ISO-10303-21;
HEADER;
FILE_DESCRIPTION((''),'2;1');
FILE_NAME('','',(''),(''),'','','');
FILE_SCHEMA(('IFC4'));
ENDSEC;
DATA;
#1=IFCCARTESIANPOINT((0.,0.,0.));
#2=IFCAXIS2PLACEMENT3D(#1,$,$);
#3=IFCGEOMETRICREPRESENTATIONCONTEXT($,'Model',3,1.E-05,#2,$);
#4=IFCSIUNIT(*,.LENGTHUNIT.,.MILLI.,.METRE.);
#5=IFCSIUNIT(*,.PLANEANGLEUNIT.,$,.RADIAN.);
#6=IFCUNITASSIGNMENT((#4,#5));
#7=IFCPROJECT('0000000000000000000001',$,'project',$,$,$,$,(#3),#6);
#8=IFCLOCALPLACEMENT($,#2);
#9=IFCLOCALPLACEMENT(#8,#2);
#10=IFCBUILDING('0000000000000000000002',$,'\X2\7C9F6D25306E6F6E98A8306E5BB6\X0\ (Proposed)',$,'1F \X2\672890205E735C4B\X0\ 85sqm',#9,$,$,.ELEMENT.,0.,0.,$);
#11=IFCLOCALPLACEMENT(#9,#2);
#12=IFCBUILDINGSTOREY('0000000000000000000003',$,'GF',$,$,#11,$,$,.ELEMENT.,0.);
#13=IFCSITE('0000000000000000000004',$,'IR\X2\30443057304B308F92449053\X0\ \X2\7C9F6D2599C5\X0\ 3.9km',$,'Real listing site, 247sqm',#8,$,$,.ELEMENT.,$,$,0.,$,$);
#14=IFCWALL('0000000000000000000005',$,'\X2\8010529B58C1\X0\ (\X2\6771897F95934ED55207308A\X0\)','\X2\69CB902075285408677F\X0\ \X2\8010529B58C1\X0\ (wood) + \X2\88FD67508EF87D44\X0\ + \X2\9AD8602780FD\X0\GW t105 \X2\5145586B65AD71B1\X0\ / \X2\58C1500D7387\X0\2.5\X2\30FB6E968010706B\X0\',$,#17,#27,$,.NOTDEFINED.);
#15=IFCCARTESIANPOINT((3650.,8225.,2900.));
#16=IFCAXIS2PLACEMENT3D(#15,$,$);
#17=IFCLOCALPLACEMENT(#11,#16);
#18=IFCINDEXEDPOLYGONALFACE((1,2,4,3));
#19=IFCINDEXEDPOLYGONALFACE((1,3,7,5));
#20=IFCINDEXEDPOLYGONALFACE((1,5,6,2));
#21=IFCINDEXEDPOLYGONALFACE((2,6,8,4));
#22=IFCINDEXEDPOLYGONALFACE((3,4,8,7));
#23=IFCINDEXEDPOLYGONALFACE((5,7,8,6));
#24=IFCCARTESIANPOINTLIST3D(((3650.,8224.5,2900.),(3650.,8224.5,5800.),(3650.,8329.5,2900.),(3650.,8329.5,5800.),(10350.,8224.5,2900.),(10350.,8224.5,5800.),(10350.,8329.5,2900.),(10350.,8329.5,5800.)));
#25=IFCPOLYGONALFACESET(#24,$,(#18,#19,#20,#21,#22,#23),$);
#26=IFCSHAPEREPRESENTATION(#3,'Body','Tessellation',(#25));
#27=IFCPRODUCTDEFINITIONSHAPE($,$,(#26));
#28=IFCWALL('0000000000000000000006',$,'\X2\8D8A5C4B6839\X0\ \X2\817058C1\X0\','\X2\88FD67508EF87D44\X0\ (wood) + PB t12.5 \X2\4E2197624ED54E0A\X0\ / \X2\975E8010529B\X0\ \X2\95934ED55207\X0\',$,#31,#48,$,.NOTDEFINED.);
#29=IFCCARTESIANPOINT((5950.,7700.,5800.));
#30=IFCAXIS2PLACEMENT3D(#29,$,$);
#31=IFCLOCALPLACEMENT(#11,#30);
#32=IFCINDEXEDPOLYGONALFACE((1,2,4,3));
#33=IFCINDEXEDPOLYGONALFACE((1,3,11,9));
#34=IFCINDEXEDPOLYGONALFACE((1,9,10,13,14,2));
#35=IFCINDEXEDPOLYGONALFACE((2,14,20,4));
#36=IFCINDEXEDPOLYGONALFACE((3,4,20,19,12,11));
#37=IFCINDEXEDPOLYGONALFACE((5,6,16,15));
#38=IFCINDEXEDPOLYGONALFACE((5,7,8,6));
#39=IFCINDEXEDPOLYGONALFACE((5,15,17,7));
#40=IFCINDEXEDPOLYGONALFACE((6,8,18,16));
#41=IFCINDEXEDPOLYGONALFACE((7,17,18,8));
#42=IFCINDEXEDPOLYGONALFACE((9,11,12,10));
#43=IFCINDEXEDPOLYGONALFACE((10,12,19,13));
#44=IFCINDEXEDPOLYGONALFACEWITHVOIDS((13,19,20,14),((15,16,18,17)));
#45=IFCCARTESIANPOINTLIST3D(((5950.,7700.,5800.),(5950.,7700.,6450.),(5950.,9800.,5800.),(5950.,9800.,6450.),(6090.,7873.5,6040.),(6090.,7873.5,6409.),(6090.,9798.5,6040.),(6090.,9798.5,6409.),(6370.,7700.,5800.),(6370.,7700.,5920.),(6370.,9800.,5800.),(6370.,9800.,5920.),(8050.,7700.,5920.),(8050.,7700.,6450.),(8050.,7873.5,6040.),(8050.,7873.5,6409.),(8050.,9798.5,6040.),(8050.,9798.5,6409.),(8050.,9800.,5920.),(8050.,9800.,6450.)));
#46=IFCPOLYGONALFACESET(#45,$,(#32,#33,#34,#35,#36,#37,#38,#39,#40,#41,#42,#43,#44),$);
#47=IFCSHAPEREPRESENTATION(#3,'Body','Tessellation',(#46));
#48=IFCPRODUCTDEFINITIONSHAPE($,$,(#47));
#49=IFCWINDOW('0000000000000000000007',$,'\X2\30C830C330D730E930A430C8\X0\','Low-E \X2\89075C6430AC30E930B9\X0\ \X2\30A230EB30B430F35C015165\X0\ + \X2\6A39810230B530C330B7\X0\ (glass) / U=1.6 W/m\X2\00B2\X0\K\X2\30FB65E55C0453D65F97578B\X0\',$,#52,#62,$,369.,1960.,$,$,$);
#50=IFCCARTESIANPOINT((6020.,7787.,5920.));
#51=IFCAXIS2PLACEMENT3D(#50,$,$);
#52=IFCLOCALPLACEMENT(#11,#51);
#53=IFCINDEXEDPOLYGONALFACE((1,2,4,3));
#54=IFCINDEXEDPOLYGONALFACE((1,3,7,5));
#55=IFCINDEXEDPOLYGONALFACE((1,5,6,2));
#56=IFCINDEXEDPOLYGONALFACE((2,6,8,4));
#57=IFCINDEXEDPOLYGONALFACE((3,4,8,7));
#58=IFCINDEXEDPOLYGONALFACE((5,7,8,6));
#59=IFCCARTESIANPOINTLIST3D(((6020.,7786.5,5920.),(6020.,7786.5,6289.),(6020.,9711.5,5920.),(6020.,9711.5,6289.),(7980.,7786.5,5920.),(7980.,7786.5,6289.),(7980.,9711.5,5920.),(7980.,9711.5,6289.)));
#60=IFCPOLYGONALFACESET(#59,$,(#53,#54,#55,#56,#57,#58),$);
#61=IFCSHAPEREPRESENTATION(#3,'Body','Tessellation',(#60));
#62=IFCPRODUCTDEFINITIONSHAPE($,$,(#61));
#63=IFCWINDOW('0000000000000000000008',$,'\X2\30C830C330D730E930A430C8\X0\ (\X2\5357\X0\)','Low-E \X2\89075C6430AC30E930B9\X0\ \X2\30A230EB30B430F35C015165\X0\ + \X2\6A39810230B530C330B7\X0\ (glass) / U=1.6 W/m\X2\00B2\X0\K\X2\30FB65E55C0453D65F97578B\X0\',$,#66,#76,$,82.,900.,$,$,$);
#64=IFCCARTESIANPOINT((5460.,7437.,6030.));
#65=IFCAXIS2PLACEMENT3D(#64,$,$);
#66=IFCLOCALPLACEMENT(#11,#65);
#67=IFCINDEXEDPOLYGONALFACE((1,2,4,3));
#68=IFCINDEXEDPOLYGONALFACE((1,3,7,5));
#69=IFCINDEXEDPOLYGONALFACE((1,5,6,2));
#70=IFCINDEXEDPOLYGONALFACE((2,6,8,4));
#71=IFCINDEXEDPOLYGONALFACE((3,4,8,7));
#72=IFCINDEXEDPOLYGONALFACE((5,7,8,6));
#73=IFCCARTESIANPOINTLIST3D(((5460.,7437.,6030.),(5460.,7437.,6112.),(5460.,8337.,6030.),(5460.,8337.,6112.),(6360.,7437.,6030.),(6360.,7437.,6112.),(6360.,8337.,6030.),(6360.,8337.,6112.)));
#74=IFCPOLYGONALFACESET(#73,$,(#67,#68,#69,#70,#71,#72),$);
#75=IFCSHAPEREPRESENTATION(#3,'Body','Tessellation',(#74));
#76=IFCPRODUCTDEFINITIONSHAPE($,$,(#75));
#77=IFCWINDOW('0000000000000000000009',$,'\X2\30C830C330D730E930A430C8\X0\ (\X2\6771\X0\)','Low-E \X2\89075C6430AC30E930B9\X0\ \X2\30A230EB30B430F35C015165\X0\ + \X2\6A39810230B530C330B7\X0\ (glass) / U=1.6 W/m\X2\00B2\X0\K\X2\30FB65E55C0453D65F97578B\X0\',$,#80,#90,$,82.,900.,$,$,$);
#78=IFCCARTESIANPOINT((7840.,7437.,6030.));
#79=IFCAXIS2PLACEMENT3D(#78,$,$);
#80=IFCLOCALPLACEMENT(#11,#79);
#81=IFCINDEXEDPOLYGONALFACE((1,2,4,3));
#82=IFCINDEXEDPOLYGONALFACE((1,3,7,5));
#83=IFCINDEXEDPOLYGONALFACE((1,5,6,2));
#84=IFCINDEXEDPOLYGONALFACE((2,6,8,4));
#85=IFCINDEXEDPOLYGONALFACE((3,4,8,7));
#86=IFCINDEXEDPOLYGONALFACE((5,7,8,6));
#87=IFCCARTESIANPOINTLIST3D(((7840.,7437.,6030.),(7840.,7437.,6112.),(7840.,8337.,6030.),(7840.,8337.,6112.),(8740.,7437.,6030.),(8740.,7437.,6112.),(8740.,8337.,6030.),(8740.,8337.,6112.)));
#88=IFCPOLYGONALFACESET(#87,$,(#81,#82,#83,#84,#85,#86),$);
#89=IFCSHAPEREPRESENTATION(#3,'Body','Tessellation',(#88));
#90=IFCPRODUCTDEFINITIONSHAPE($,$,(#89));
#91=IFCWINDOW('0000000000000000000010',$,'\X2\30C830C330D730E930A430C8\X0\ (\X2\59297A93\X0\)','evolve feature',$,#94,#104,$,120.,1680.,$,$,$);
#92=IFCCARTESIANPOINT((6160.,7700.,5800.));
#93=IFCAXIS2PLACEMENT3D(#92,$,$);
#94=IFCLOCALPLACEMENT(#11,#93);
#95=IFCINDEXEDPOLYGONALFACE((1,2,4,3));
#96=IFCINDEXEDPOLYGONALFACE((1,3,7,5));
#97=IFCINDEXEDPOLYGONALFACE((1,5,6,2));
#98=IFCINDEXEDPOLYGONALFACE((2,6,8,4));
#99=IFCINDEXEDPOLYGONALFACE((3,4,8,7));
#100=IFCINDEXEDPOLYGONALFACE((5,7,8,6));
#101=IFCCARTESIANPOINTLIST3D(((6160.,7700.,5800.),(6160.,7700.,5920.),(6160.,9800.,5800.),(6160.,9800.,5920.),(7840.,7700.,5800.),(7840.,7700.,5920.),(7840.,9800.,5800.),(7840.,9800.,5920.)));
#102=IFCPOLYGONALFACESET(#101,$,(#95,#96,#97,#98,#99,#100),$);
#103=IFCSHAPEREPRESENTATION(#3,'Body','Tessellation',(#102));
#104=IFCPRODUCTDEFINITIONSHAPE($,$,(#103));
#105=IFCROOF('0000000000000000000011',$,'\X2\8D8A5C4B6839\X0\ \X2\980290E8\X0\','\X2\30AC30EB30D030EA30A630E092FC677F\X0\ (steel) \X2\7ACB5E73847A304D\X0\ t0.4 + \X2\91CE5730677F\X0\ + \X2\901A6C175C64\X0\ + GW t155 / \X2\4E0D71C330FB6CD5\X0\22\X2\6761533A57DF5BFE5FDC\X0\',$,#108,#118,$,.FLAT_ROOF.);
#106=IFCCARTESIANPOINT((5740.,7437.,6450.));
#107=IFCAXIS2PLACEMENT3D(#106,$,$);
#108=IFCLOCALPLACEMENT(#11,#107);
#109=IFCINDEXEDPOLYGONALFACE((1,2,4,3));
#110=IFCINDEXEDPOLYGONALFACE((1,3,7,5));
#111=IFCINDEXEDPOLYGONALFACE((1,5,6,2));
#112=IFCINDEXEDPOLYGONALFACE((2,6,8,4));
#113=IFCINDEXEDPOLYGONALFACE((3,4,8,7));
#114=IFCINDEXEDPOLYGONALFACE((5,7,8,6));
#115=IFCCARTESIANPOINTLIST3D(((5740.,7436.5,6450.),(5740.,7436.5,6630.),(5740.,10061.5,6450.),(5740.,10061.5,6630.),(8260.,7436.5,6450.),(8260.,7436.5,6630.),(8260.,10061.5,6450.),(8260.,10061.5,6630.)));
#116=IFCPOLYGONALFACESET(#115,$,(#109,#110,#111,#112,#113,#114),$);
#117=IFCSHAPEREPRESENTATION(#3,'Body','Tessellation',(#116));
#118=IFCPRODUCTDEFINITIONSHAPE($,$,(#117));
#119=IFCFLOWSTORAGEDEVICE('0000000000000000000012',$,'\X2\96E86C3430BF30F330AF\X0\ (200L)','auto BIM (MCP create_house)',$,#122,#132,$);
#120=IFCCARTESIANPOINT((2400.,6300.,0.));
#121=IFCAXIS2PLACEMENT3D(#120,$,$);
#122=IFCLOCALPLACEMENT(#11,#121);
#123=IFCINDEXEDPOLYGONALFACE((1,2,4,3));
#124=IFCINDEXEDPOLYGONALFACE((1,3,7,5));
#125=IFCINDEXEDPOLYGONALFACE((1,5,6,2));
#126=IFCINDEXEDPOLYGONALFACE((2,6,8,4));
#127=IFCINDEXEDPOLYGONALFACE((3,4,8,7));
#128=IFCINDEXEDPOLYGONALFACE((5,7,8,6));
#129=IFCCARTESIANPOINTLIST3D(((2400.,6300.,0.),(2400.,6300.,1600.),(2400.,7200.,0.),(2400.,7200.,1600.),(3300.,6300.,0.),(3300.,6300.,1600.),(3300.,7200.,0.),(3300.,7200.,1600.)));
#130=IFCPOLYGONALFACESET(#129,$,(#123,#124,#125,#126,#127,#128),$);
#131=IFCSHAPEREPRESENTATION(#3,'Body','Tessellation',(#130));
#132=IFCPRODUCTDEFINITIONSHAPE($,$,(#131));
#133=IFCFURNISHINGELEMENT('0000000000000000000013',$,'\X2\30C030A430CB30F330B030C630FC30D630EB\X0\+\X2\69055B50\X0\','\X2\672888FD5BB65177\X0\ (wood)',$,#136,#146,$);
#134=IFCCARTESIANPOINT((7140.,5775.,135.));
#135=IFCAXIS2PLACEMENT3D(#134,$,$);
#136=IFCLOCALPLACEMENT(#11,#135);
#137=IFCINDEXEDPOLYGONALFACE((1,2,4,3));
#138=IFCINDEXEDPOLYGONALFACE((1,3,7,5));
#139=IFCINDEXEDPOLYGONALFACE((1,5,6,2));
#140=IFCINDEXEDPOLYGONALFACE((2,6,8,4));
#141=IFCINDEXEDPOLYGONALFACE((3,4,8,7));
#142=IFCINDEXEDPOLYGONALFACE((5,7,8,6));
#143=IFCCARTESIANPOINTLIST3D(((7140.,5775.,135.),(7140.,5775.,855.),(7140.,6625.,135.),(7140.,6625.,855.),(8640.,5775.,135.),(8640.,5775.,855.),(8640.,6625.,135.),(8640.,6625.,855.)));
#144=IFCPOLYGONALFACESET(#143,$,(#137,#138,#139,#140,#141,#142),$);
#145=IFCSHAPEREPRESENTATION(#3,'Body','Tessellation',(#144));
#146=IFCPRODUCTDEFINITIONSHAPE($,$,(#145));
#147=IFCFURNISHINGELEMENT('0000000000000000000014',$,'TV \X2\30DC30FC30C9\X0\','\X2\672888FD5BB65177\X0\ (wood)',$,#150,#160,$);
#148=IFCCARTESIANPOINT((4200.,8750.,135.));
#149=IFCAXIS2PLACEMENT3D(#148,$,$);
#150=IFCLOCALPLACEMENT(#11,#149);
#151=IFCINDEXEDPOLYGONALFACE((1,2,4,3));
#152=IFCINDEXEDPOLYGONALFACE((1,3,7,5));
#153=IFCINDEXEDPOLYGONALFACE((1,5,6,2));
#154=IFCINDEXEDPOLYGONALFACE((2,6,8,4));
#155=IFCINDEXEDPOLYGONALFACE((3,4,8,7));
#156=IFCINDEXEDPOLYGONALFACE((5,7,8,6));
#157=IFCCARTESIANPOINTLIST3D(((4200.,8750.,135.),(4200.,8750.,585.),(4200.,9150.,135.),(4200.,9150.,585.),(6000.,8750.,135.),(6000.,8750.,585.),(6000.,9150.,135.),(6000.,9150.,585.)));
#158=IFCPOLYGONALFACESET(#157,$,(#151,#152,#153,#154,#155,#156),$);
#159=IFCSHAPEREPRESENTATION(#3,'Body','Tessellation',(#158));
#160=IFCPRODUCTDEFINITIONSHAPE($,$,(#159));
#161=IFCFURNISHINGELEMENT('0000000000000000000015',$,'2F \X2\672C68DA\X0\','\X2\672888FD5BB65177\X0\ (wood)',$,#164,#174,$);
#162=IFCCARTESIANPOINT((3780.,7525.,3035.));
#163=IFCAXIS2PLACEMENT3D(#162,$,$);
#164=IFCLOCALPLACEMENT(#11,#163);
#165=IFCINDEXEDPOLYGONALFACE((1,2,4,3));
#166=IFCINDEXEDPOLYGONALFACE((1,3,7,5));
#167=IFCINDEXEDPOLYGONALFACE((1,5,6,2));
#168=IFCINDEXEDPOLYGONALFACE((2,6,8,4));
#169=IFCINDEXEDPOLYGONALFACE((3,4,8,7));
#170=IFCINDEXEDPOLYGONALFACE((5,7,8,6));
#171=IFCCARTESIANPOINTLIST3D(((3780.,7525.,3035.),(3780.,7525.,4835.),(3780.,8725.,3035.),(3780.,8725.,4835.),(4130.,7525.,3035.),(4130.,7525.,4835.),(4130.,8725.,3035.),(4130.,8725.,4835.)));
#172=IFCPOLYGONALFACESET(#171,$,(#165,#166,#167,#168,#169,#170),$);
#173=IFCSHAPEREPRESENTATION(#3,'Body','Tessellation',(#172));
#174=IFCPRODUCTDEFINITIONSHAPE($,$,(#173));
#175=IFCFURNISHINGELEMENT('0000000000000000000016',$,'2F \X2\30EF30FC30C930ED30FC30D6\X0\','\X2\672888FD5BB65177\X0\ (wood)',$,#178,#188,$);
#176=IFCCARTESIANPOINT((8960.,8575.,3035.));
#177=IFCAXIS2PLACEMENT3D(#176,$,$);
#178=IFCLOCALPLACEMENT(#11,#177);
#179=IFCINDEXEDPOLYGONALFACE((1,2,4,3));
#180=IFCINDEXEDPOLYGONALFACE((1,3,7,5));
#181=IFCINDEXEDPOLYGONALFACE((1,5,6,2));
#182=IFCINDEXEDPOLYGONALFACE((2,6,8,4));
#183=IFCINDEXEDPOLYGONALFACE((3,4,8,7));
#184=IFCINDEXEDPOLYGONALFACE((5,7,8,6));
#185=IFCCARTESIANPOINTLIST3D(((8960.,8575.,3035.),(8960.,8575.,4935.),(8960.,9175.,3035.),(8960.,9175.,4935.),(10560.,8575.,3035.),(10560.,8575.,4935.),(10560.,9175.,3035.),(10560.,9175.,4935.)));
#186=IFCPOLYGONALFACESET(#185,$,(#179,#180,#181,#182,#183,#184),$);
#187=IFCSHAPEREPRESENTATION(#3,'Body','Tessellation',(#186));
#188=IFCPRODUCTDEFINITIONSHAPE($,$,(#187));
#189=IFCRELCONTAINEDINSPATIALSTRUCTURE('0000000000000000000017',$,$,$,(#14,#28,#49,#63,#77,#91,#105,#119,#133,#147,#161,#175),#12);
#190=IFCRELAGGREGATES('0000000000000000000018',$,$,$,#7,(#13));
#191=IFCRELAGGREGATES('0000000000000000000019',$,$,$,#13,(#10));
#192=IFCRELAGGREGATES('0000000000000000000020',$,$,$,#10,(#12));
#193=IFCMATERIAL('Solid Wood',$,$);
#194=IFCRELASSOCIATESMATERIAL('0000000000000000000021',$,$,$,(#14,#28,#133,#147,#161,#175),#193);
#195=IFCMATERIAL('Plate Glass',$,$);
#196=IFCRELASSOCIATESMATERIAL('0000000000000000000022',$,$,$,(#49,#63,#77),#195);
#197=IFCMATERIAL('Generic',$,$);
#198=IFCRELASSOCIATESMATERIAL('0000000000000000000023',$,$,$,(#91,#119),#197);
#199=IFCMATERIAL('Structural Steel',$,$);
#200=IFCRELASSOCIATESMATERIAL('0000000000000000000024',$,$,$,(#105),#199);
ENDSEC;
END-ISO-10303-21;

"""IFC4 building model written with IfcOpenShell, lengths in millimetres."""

from ifc_helpers import new_model, si_unit, frame, frame_2d, origin, place, context, project, spatial, rectangle, extrude, material, element, fill, save


model = new_model("IFC4")

# Units and contexts
model_context = context("Model", 3, precision=1e-05, world=origin())
ifc_project = project(units=[si_unit("LENGTHUNIT", "METRE", prefix="MILLI"), si_unit("PLANEANGLEUNIT", "RADIAN")], contexts=[model_context])

# Site, building, storey
site_placement = place(None, origin())
site = spatial("IfcSite", under=ifc_project, at=site_placement, Name="IRいしかわ鉄道 粟津駅 3.9km", ObjectType="Real listing site, 247sqm", CompositionType="ELEMENT", RefElevation=0.0)
building_placement = place(site_placement, origin())
building = spatial("IfcBuilding", under=site, at=building_placement, Name="粟津の潮風の家 (Proposed)", ObjectType="1F 木造平屋 85sqm", CompositionType="ELEMENT", ElevationOfRefHeight=0.0, ElevationOfTerrain=0.0)
storey_placement = place(building_placement, origin())
storey = spatial("IfcBuildingStorey", under=building, at=storey_placement, Name="GF", CompositionType="ELEMENT", Elevation=0.0)

# Wall
ifc_material_1 = material(Name="Solid Wood")
wall_1_placement = place(storey_placement, frame((3650.0, 8225.0, 2900.0)))
element("IfcWall", 1, at=wall_1_placement, inside=storey, material=ifc_material_1, Name="耐力壁 (東西間仕切り)", Description="構造用合板 耐力壁 (wood) + 製材軸組 + 高性能GW t105 充填断熱 / 壁倍率2.5・準耐火", PredefinedType="NOTDEFINED", context=model_context, shape_type="SweptSolid", body=[
    extrude(rectangle(XDim=6700.0, YDim=105.0, at=frame_2d((3350.0, 52.0))), frame((3650.0, 8225.0, 2900.0)), (0.0, 0.0, 1.0), 2900.0),
])

# Wall, openings, windows
wall_2_placement = place(storey_placement, frame((5950.0, 7700.0, 5800.0)))
wall_2 = element("IfcWall", 2, at=wall_2_placement, inside=storey, material=ifc_material_1, Name="越屋根 腰壁", Description="製材軸組 (wood) + PB t12.5 両面仕上 / 非耐力 間仕切", PredefinedType="NOTDEFINED", context=model_context, shape_type="SweptSolid", body=[
    extrude(rectangle(XDim=2100.0, YDim=2100.0, at=frame_2d((1050.0, 1050.0))), frame((5950.0, 7700.0, 5800.0)), (0.0, 0.0, 1.0), 650.0),
])
opening_1_placement = place(storey_placement, frame((6020.0, 7787.0, 5920.0)))
opening_1 = element("IfcOpeningElement", 3, at=opening_1_placement, cuts=wall_2, PredefinedType="NOTDEFINED", context=model_context, shape_type="SweptSolid", body=[
    extrude(rectangle(XDim=1960.0, YDim=1925.0, at=frame_2d((980.0, 962.0))), frame((6020.0, 7787.0, 5920.0)), (0.0, 0.0, 1.0), 369.0),
])
opening_2_placement = place(storey_placement, frame((5460.0, 7437.0, 6030.0)))
opening_2 = element("IfcOpeningElement", 4, at=opening_2_placement, cuts=wall_2, PredefinedType="NOTDEFINED", context=model_context, shape_type="SweptSolid", body=[
    extrude(rectangle(XDim=900.0, YDim=900.0, at=frame_2d((450.0, 450.0))), frame((5460.0, 7437.0, 6030.0)), (0.0, 0.0, 1.0), 82.0),
])
opening_3_placement = place(storey_placement, frame((7840.0, 7437.0, 6030.0)))
opening_3 = element("IfcOpeningElement", 5, at=opening_3_placement, cuts=wall_2, PredefinedType="NOTDEFINED", context=model_context, shape_type="SweptSolid", body=[
    extrude(rectangle(XDim=900.0, YDim=900.0, at=frame_2d((450.0, 450.0))), frame((7840.0, 7437.0, 6030.0)), (0.0, 0.0, 1.0), 82.0),
])
opening_4_placement = place(storey_placement, frame((6160.0, 7700.0, 5800.0)))
opening_4 = element("IfcOpeningElement", 6, at=opening_4_placement, cuts=wall_2, PredefinedType="NOTDEFINED", context=model_context, shape_type="SweptSolid", body=[
    extrude(rectangle(XDim=1680.0, YDim=2100.0, at=frame_2d((840.0, 1050.0))), frame((6160.0, 7700.0, 5800.0)), (0.0, 0.0, 1.0), 120.0),
])
ifc_material_2 = material(Name="Plate Glass")
window_1_placement = place(storey_placement, frame((6020.0, 7787.0, 5920.0)))
window_1 = element("IfcWindow", 7, at=window_1_placement, inside=storey, material=ifc_material_2, Name="トップライト", Description="Low-E 複層ガラス アルゴン封入 + 樹脂サッシ (glass) / U=1.6 W/m²K・日射取得型", OverallHeight=369.0, OverallWidth=1960.0, context=model_context, shape_type="SweptSolid", body=[
    extrude(rectangle(XDim=1960.0, YDim=1925.0, at=frame_2d((980.0, 962.0))), frame((6020.0, 7787.0, 5920.0)), (0.0, 0.0, 1.0), 369.0),
])
fill(opening_1, window_1)
window_2_placement = place(storey_placement, frame((5460.0, 7437.0, 6030.0)))
window_2 = element("IfcWindow", 8, at=window_2_placement, inside=storey, material=ifc_material_2, Name="トップライト (南)", Description="Low-E 複層ガラス アルゴン封入 + 樹脂サッシ (glass) / U=1.6 W/m²K・日射取得型", OverallHeight=82.0, OverallWidth=900.0, context=model_context, shape_type="SweptSolid", body=[
    extrude(rectangle(XDim=900.0, YDim=900.0, at=frame_2d((450.0, 450.0))), frame((5460.0, 7437.0, 6030.0)), (0.0, 0.0, 1.0), 82.0),
])
fill(opening_2, window_2)
window_3_placement = place(storey_placement, frame((7840.0, 7437.0, 6030.0)))
window_3 = element("IfcWindow", 9, at=window_3_placement, inside=storey, material=ifc_material_2, Name="トップライト (東)", Description="Low-E 複層ガラス アルゴン封入 + 樹脂サッシ (glass) / U=1.6 W/m²K・日射取得型", OverallHeight=82.0, OverallWidth=900.0, context=model_context, shape_type="SweptSolid", body=[
    extrude(rectangle(XDim=900.0, YDim=900.0, at=frame_2d((450.0, 450.0))), frame((7840.0, 7437.0, 6030.0)), (0.0, 0.0, 1.0), 82.0),
])
fill(opening_3, window_3)
ifc_material_3 = material(Name="Generic")
window_4_placement = place(storey_placement, frame((6160.0, 7700.0, 5800.0)))
window_4 = element("IfcWindow", 10, at=window_4_placement, inside=storey, material=ifc_material_3, Name="トップライト (天窓)", Description="evolve feature", OverallHeight=120.0, OverallWidth=1680.0, context=model_context, shape_type="SweptSolid", body=[
    extrude(rectangle(XDim=1680.0, YDim=2100.0, at=frame_2d((840.0, 1050.0))), frame((6160.0, 7700.0, 5800.0)), (0.0, 0.0, 1.0), 120.0),
])
fill(opening_4, window_4)

# Roof
ifc_material_4 = material(Name="Structural Steel")
roof_placement = place(storey_placement, frame((5740.0, 7437.0, 6450.0)))
element("IfcRoof", 11, at=roof_placement, inside=storey, material=ifc_material_4, Name="越屋根 頂部", Description="ガルバリウム鋼板 (steel) 立平葺き t0.4 + 野地板 + 通気層 + GW t155 / 不燃・法22条区域対応", PredefinedType="FLAT_ROOF", context=model_context, shape_type="SweptSolid", body=[
    extrude(rectangle(XDim=2520.0, YDim=2625.0, at=frame_2d((1260.0, 1312.0))), frame((5740.0, 7437.0, 6450.0)), (0.0, 0.0, 1.0), 180.0),
])

# Flow storage device
flow_storage_device_placement = place(storey_placement, frame((2400.0, 6300.0, 0.0)))
element("IfcFlowStorageDevice", 12, at=flow_storage_device_placement, inside=storey, material=ifc_material_3, Name="雨水タンク (200L)", Description="auto BIM (MCP create_house)", context=model_context, shape_type="SweptSolid", body=[
    extrude(rectangle(XDim=900.0, YDim=900.0, at=frame_2d((450.0, 450.0))), frame((2400.0, 6300.0, 0.0)), (0.0, 0.0, 1.0), 1600.0),
])

# Furnishing elements
furnishing_1_placement = place(storey_placement, frame((7140.0, 5775.0, 135.0)))
element("IfcFurnishingElement", 13, at=furnishing_1_placement, inside=storey, material=ifc_material_1, Name="ダイニングテーブル+椅子", Description="木製家具 (wood)", context=model_context, shape_type="SweptSolid", body=[
    extrude(rectangle(XDim=1500.0, YDim=850.0, at=frame_2d((750.0, 425.0))), frame((7140.0, 5775.0, 135.0)), (0.0, 0.0, 1.0), 720.0),
])
furnishing_2_placement = place(storey_placement, frame((4200.0, 8750.0, 135.0)))
element("IfcFurnishingElement", 14, at=furnishing_2_placement, inside=storey, material=ifc_material_1, Name="TV ボード", Description="木製家具 (wood)", context=model_context, shape_type="SweptSolid", body=[
    extrude(rectangle(XDim=1800.0, YDim=400.0, at=frame_2d((900.0, 200.0))), frame((4200.0, 8750.0, 135.0)), (0.0, 0.0, 1.0), 450.0),
])
furnishing_3_placement = place(storey_placement, frame((3780.0, 7525.0, 3035.0)))
element("IfcFurnishingElement", 15, at=furnishing_3_placement, inside=storey, material=ifc_material_1, Name="2F 本棚", Description="木製家具 (wood)", context=model_context, shape_type="SweptSolid", body=[
    extrude(rectangle(XDim=350.0, YDim=1200.0, at=frame_2d((175.0, 600.0))), frame((3780.0, 7525.0, 3035.0)), (0.0, 0.0, 1.0), 1800.0),
])
furnishing_4_placement = place(storey_placement, frame((8960.0, 8575.0, 3035.0)))
element("IfcFurnishingElement", 16, at=furnishing_4_placement, inside=storey, material=ifc_material_1, Name="2F ワードローブ", Description="木製家具 (wood)", context=model_context, shape_type="SweptSolid", body=[
    extrude(rectangle(XDim=1600.0, YDim=600.0, at=frame_2d((800.0, 300.0))), frame((8960.0, 8575.0, 3035.0)), (0.0, 0.0, 1.0), 1900.0),
])

save(model, "model.ifc")
